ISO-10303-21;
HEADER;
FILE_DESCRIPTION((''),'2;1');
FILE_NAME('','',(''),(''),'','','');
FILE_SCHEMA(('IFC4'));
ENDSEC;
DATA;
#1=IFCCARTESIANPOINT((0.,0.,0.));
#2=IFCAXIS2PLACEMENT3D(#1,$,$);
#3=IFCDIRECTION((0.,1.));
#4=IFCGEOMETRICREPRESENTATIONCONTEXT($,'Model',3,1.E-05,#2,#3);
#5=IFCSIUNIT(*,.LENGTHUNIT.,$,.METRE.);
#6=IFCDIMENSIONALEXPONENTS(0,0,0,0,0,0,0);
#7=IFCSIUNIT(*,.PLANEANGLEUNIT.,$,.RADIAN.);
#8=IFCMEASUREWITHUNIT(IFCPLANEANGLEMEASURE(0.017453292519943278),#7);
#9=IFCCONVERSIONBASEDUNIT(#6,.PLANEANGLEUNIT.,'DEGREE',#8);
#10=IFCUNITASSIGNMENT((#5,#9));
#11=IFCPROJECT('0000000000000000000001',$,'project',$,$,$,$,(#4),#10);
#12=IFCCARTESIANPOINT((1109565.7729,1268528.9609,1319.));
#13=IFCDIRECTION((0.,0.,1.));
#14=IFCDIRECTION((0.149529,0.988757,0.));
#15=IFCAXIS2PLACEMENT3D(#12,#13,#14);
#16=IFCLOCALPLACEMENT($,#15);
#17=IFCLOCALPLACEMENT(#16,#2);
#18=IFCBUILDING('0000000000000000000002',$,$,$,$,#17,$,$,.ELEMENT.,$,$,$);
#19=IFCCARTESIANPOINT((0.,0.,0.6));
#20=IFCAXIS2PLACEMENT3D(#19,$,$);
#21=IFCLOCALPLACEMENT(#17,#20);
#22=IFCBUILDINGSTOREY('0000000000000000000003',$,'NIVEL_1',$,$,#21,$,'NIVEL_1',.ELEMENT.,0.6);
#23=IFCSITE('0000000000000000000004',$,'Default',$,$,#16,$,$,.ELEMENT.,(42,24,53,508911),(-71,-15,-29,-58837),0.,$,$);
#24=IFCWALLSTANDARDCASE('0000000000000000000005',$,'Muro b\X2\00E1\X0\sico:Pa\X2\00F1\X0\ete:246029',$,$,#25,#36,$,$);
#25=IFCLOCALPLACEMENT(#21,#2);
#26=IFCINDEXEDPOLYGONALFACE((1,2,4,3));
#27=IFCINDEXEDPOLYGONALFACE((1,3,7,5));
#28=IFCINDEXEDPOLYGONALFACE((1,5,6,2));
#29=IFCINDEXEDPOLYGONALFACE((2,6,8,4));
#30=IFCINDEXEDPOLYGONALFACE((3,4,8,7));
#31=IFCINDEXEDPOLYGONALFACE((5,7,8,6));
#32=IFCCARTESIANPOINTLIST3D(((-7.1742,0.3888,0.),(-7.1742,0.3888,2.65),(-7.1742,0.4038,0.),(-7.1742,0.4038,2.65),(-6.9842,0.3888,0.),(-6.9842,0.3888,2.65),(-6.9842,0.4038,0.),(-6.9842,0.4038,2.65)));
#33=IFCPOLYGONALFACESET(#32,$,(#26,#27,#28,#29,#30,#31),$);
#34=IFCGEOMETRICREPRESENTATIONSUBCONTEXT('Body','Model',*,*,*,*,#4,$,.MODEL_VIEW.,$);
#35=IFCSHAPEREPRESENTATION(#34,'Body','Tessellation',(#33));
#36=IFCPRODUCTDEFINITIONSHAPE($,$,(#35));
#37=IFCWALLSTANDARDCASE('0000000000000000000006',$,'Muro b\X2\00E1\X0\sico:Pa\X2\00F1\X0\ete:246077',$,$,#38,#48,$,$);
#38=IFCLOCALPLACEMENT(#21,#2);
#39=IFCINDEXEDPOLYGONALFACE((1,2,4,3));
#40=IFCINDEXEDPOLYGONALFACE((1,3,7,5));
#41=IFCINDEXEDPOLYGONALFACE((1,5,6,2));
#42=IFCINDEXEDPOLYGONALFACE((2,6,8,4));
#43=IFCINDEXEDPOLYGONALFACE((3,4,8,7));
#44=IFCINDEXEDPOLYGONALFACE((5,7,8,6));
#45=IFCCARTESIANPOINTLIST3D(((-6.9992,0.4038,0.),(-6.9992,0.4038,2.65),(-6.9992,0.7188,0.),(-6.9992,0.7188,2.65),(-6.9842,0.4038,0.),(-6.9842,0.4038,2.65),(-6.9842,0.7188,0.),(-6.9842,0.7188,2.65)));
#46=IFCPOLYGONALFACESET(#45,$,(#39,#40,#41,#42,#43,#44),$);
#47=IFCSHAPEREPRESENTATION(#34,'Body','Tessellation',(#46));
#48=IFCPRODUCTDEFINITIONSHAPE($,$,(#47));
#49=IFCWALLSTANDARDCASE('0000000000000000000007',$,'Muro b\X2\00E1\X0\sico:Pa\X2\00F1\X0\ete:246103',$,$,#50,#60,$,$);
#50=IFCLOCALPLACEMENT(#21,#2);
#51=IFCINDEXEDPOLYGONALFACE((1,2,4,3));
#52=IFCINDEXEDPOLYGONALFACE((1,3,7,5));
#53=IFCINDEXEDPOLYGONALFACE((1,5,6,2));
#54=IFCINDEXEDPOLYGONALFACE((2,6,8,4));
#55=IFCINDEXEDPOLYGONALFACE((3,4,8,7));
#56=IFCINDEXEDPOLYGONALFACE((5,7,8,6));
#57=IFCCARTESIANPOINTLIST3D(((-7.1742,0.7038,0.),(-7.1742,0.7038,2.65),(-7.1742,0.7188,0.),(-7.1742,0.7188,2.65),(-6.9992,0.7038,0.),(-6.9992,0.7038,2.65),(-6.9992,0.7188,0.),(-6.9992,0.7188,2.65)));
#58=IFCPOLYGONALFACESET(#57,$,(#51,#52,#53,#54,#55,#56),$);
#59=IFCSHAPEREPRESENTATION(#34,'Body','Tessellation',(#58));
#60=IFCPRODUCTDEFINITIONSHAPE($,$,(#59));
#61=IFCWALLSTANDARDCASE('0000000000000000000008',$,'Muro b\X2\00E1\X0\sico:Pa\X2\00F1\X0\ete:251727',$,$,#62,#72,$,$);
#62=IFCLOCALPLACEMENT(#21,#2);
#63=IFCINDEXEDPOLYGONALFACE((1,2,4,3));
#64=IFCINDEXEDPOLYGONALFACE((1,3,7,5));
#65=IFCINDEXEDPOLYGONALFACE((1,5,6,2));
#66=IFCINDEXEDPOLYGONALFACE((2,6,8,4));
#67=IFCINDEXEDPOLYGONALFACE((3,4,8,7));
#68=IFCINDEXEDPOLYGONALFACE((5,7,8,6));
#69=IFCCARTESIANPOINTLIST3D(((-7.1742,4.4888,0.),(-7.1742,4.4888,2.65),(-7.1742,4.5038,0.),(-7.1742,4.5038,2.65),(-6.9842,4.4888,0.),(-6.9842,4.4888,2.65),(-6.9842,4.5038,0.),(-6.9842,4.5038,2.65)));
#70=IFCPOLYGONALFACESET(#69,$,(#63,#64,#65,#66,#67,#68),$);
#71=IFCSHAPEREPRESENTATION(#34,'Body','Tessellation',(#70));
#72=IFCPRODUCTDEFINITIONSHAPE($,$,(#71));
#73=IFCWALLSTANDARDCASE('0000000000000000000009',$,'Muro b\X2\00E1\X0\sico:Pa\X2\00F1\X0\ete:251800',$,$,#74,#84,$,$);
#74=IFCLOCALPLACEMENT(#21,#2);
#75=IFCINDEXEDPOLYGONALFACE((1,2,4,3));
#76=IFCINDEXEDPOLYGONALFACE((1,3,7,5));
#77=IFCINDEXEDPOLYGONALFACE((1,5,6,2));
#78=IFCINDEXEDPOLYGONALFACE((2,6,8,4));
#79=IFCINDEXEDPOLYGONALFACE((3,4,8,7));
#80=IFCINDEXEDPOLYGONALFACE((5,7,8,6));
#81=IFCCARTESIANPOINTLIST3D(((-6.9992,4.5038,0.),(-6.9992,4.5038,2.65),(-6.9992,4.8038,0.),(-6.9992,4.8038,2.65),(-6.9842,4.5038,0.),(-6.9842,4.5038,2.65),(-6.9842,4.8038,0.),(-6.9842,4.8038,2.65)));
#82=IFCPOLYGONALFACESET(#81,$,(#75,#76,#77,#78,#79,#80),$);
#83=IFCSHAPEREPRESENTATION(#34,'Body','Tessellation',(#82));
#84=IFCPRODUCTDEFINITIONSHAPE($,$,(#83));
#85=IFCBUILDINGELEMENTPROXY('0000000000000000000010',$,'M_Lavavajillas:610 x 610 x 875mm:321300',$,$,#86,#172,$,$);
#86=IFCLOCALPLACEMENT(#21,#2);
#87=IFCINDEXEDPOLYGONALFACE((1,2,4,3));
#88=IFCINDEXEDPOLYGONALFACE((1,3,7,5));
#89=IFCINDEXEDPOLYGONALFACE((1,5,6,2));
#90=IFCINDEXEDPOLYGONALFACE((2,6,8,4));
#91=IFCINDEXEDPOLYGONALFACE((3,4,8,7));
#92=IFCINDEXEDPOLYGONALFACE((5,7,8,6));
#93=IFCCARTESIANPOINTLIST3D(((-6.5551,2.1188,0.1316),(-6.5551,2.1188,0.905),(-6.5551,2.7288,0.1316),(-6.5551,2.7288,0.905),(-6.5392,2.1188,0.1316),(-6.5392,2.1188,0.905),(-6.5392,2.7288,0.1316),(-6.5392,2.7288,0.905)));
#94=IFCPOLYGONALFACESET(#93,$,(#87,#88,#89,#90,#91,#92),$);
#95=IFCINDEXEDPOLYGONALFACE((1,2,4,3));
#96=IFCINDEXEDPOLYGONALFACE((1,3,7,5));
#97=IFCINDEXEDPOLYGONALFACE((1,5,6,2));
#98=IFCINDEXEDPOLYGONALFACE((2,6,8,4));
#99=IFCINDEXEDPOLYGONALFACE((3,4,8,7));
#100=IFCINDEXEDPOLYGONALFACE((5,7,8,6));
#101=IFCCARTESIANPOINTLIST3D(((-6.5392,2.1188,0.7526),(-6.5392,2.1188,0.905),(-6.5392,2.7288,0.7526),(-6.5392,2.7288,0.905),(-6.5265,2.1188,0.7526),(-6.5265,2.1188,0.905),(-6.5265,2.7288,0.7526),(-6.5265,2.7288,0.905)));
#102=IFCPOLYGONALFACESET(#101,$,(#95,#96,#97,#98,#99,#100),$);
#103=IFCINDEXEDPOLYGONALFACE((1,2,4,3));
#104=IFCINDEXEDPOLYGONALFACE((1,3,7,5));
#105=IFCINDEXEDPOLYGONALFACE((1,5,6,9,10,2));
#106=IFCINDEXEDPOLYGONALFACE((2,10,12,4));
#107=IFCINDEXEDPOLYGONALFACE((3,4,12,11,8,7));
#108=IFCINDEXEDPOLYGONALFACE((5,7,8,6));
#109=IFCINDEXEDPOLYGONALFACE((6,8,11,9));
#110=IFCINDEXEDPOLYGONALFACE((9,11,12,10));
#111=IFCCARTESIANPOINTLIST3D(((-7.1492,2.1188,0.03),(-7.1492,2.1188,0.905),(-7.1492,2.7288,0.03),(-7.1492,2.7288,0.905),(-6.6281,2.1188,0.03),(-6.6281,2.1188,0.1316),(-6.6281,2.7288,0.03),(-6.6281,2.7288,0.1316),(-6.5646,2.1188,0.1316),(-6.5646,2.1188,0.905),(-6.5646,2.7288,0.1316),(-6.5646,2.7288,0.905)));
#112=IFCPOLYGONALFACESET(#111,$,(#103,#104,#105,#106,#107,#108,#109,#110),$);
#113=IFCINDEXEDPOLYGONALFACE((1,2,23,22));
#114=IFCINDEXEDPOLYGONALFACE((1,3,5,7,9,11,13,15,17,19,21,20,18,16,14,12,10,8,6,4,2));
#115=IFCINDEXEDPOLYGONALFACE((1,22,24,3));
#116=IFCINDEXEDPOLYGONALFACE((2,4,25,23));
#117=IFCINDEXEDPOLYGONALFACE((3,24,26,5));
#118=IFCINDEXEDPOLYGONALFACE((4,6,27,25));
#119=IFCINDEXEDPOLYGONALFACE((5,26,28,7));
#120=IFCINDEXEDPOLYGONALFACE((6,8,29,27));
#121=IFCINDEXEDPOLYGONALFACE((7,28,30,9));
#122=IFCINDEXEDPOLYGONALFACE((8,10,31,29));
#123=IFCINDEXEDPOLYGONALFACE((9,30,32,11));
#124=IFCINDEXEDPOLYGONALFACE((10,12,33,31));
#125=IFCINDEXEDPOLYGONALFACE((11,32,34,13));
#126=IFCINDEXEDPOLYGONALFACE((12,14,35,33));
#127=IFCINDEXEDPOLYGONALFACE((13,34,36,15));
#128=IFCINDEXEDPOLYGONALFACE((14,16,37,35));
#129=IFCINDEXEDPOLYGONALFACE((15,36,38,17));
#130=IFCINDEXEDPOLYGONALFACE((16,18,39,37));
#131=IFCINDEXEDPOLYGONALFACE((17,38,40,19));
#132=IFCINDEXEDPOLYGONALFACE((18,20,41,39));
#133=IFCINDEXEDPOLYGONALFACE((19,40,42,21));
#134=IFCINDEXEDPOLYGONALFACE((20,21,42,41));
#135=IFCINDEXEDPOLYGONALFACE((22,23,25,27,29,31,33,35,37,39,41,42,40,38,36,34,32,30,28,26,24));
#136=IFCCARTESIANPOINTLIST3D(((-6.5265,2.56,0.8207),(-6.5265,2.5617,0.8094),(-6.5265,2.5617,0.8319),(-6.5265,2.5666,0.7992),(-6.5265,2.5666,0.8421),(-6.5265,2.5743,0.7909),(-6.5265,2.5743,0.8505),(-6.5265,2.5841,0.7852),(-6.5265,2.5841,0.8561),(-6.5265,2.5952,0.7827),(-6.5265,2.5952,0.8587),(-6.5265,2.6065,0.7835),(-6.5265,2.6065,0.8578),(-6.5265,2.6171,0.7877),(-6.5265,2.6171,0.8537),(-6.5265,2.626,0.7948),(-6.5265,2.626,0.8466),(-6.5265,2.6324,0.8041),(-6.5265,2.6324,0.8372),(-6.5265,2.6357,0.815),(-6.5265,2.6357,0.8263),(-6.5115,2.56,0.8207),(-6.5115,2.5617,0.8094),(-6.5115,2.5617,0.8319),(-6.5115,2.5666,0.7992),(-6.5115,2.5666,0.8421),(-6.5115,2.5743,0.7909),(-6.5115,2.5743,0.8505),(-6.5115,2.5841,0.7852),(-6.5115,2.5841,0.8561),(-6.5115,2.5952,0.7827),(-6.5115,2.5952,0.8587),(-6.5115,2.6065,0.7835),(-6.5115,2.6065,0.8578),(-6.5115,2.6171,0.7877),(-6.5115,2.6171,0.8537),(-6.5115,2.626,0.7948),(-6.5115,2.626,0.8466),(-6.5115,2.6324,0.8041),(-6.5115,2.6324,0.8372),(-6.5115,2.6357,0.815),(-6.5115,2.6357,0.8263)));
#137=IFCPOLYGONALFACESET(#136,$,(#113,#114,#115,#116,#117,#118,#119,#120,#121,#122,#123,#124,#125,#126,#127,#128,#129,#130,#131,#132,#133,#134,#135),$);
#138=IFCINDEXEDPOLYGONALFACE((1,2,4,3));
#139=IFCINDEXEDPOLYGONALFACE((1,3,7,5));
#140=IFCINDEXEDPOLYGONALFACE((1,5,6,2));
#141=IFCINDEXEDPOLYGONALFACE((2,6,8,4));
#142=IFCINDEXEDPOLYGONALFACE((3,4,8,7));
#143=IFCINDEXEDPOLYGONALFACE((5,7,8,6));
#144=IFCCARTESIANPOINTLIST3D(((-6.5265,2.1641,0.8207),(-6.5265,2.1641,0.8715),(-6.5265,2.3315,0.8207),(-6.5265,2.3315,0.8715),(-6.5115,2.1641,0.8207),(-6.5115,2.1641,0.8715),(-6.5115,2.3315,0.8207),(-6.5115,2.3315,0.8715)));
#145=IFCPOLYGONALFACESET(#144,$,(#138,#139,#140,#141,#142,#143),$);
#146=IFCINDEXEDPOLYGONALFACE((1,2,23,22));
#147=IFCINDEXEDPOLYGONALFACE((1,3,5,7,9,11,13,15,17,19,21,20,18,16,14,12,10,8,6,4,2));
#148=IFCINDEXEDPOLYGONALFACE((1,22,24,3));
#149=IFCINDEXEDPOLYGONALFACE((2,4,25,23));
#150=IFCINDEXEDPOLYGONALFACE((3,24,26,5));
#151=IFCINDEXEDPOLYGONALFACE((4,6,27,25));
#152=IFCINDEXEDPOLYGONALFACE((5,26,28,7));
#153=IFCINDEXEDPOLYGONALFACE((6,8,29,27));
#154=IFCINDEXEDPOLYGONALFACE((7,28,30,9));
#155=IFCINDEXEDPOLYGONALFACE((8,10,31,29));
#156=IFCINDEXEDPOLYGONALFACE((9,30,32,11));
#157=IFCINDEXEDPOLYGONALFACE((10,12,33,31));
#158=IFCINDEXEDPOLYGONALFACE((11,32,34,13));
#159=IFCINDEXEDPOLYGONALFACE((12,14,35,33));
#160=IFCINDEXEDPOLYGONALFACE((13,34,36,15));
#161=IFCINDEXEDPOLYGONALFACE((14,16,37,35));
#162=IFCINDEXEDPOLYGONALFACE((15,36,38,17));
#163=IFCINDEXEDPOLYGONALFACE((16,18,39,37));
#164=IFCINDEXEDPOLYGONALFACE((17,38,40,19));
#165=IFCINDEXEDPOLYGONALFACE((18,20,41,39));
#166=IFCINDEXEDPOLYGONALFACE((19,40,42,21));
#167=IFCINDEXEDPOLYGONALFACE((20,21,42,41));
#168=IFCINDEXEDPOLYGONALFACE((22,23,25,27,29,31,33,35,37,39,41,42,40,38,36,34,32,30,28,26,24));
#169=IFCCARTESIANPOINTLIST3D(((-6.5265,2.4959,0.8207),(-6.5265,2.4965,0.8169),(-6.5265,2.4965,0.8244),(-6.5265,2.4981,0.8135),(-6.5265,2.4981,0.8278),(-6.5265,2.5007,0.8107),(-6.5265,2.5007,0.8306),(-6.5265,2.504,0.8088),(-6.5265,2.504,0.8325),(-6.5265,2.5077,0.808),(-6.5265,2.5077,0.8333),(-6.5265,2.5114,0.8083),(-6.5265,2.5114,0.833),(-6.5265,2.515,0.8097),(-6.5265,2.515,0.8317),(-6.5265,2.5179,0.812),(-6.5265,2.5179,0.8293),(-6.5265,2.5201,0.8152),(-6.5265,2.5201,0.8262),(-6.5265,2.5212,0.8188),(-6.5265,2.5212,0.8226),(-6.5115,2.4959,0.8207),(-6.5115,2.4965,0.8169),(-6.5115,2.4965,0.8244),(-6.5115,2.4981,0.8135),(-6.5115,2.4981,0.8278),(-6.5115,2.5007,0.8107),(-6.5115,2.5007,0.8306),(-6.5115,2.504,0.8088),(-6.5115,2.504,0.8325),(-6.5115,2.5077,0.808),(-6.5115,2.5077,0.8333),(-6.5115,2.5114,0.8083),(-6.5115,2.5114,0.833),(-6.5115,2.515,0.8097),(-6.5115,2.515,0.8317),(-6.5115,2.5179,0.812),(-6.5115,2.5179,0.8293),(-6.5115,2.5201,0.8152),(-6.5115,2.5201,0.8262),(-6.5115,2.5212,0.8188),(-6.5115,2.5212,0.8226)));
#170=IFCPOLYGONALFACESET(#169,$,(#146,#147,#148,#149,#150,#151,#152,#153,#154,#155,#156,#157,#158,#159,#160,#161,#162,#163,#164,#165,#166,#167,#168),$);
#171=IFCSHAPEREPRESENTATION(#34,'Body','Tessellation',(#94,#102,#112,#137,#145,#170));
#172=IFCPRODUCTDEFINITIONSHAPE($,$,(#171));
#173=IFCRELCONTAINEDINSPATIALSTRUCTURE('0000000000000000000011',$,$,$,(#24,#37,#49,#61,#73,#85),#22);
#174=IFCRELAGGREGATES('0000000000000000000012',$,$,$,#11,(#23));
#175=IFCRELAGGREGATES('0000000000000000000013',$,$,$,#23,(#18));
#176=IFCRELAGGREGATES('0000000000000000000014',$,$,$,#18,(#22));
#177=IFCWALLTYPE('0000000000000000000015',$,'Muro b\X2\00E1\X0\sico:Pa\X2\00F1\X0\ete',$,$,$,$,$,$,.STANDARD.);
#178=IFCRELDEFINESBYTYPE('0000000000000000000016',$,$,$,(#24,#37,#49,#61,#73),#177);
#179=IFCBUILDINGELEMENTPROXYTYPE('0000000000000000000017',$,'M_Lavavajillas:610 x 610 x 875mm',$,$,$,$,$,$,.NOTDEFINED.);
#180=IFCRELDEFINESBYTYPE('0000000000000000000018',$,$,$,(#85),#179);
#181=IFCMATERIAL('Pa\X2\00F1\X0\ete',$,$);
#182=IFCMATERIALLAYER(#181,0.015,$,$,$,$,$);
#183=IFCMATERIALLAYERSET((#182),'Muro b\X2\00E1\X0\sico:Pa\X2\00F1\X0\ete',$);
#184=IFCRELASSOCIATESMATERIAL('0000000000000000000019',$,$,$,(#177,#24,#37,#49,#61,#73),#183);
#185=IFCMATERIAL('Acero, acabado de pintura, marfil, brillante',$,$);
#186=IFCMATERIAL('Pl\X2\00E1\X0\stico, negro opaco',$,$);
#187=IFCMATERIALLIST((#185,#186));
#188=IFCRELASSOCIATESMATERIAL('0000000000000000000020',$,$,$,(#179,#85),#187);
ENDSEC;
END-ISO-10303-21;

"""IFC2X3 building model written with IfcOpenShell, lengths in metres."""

from ifc_helpers import new_model, entity, si_unit, converted_unit, direction, frame, frame_2d, origin, origin_2d_with_axis, place, context, subcontext, project, spatial, polyline, rectangle, circle, outline, extrude, source, transform, mapped, material, material_list, layer, layer_set, layer_usage, type_object, type_shapes, element, save


model = new_model("IFC2X3")

# Units and contexts
model_context = context("Model", 3, precision=1e-05, world=origin(), true_north=direction((0.0, 1.0)))
body_context = subcontext(model_context, "Body", "Model", "MODEL_VIEW")
ifc_project = project(units=[si_unit("LENGTHUNIT", "METRE"), converted_unit("PLANEANGLEUNIT", "DEGREE", entity("IfcPlaneAngleMeasure", 0.017453292519943278), si_unit("PLANEANGLEUNIT", "RADIAN"), dimensions=[0, 0, 0, 0, 0, 0, 0])], contexts=[model_context])

# Site, building, storey
site_placement = place(None, frame((1109565.7729, 1268528.9609, 1319.0), z_axis=(0.0, 0.0, 1.0), x_axis=(0.149529, 0.988757, 0.0)))
site = spatial("IfcSite", under=ifc_project, at=site_placement, Name="Default", CompositionType="ELEMENT", RefLatitude=(42, 24, 53, 508911), RefLongitude=(-71, -15, -29, -58837), RefElevation=0.0)
building_placement = place(site_placement, origin())
building = spatial("IfcBuilding", under=site, at=building_placement, CompositionType="ELEMENT")
storey_placement = place(building_placement, frame((0.0, 0.0, 0.6)))
storey = spatial("IfcBuildingStorey", under=building, at=storey_placement, Name="NIVEL_1", LongName="NIVEL_1", CompositionType="ELEMENT", Elevation=0.6)

# Shared definitions
ifc_material_1 = material(Name="Pañete")

# Walls
ifc_layer_1 = layer(ifc_material_1, 0.015)
ifc_layer_set_1 = layer_set([ifc_layer_1], Name="Muro básico:Pañete")
wall_type_1 = type_object("IfcWallType", Name="Muro básico:Pañete", PredefinedType="STANDARD", material=ifc_layer_set_1)
ifc_layer_usage_1 = layer_usage(ifc_layer_set_1, "AXIS2", "POSITIVE", -0.0075)
wall_1_placement = place(storey_placement, frame((-7.1742, 0.3963, 0.0)))
element("IfcWallStandardCase", 1, at=wall_1_placement, inside=storey, type_object=wall_type_1, material=ifc_layer_usage_1, Name="Muro básico:Pañete:246029", context=body_context, shape_type="SweptSolid", body=[
    extrude(rectangle(XDim=0.19, YDim=0.015, at=frame_2d((0.095, 0.0), x_axis=(-1.0, 0.0))), origin(), (0.0, 0.0, 1.0), 2.65),
])
ifc_layer_usage_2 = layer_usage(ifc_layer_set_1, "AXIS2", "POSITIVE", -0.0075)
wall_2_placement = place(storey_placement, frame((-6.9917, 0.4038, 0.0), z_axis=(0.0, 0.0, 1.0), x_axis=(0.0, 1.0, 0.0)))
element("IfcWallStandardCase", 2, at=wall_2_placement, inside=storey, type_object=wall_type_1, material=ifc_layer_usage_2, Name="Muro básico:Pañete:246077", context=body_context, shape_type="SweptSolid", body=[
    extrude(rectangle(XDim=0.315, YDim=0.015, at=frame_2d((0.1575, 0.0), x_axis=(-1.0, 0.0))), origin(), (0.0, 0.0, 1.0), 2.65),
])
ifc_layer_usage_3 = layer_usage(ifc_layer_set_1, "AXIS2", "POSITIVE", -0.0075)
wall_3_placement = place(storey_placement, frame((-6.9992, 0.7113, 0.0), z_axis=(0.0, 0.0, 1.0), x_axis=(-1.0, 0.0, 0.0)))
element("IfcWallStandardCase", 3, at=wall_3_placement, inside=storey, type_object=wall_type_1, material=ifc_layer_usage_3, Name="Muro básico:Pañete:246103", context=body_context, shape_type="SweptSolid", body=[
    extrude(rectangle(XDim=0.175, YDim=0.015, at=frame_2d((0.0875, 0.0), x_axis=(-1.0, 0.0))), origin(), (0.0, 0.0, 1.0), 2.65),
])
ifc_layer_usage_4 = layer_usage(ifc_layer_set_1, "AXIS2", "POSITIVE", -0.0075)
wall_4_placement = place(storey_placement, frame((-7.1742, 4.4963, 0.0)))
element("IfcWallStandardCase", 4, at=wall_4_placement, inside=storey, type_object=wall_type_1, material=ifc_layer_usage_4, Name="Muro básico:Pañete:251727", context=body_context, shape_type="SweptSolid", body=[
    extrude(rectangle(XDim=0.19, YDim=0.015, at=frame_2d((0.095, 0.0), x_axis=(-1.0, 0.0))), origin(), (0.0, 0.0, 1.0), 2.65),
])
ifc_layer_usage_5 = layer_usage(ifc_layer_set_1, "AXIS2", "POSITIVE", -0.0075)
wall_5_placement = place(storey_placement, frame((-6.9917, 4.5038, 0.0), z_axis=(0.0, 0.0, 1.0), x_axis=(0.0, 1.0, 0.0)))
element("IfcWallStandardCase", 5, at=wall_5_placement, inside=storey, type_object=wall_type_1, material=ifc_layer_usage_5, Name="Muro básico:Pañete:251800", context=body_context, shape_type="SweptSolid", body=[
    extrude(rectangle(XDim=0.3, YDim=0.015, at=frame_2d((0.15, 0.0), x_axis=(-1.0, 0.0))), origin(), (0.0, 0.0, 1.0), 2.65),
])

# Building element proxy
ifc_material_2 = material(Name="Acero, acabado de pintura, marfil, brillante")
ifc_material_3 = material(Name="Plástico, negro opaco")
ifc_material_list_1 = material_list([ifc_material_2, ifc_material_3])
building_element_proxy_type = type_object("IfcBuildingElementProxyType", Name="M_Lavavajillas:610 x 610 x 875mm", PredefinedType="NOTDEFINED", material=ifc_material_list_1)
shared_shape_1 = source(origin(), body_context, "Body", "SweptSolid", [
    extrude(rectangle(XDim=0.0159, YDim=0.61, at=origin_2d_with_axis()), frame((0.3825, -0.0304, 0.1016), z_axis=(0.0, 0.0, 1.0), x_axis=(0.0, 1.0, 0.0)), (0.0, 0.0, 1.0), 0.7734),
    extrude(rectangle(XDim=0.61, YDim=0.0127, at=origin_2d_with_axis()), frame((0.3825, -0.0447, 0.7226), z_axis=(0.0, 0.0, 1.0), x_axis=(-1.0, 0.0, 0.0)), (0.0, 0.0, 1.0), 0.1524),
    extrude(outline(polyline([(-0.3255, -0.3686), (0.5495, -0.3686), (0.5495, 0.216), (-0.2239, 0.216), (-0.2239, 0.1525), (-0.3255, 0.1525), (-0.3255, -0.3686)])), frame((0.0775, 0.2031, 0.3255), z_axis=(1.0, 0.0, 0.0), x_axis=(0.0, 0.0, 1.0)), (0.0, 0.0, 1.0), 0.61),
    extrude(circle(Radius=0.0381, at=frame_2d((0.0, 0.0), x_axis=(1.0, 0.0))), frame((0.5568, -0.0661, 0.7907), z_axis=(0.0, 1.0, 0.0), x_axis=(-1.0, 0.0, 0.0)), (0.0, 0.0, 1.0), 0.015),
    extrude(rectangle(XDim=0.015, YDim=0.1674, at=frame_2d((0.0, 0.0), x_axis=(1.0, 0.0))), frame((0.2065, -0.0586, 0.7907), z_axis=(0.0, 0.0, 1.0), x_axis=(0.0, 1.0, 0.0)), (0.0, 0.0, 1.0), 0.0508),
    extrude(circle(Radius=0.0127, at=frame_2d((0.0, 0.0), x_axis=(1.0, 0.0))), frame((0.4673, -0.0661, 0.7907), z_axis=(0.0, 1.0, 0.0), x_axis=(-1.0, 0.0, 0.0)), (0.0, 0.0, 1.0), 0.015),
])
type_shapes(building_element_proxy_type, [shared_shape_1])
proxy_placement = place(storey_placement, frame((-6.5776, 2.0413, 0.03), z_axis=(0.0, 0.0, 1.0), x_axis=(0.0, 1.0, 0.0)))
element("IfcBuildingElementProxy", 6, at=proxy_placement, inside=storey, type_object=building_element_proxy_type, material=ifc_material_list_1, Name="M_Lavavajillas:610 x 610 x 875mm:321300", context=body_context, shape_type="MappedRepresentation", body=[
    mapped(shared_shape_1, transform((0.0, 0.0, 0.0), scale=1.0)),
])

save(model, "model.ifc")
